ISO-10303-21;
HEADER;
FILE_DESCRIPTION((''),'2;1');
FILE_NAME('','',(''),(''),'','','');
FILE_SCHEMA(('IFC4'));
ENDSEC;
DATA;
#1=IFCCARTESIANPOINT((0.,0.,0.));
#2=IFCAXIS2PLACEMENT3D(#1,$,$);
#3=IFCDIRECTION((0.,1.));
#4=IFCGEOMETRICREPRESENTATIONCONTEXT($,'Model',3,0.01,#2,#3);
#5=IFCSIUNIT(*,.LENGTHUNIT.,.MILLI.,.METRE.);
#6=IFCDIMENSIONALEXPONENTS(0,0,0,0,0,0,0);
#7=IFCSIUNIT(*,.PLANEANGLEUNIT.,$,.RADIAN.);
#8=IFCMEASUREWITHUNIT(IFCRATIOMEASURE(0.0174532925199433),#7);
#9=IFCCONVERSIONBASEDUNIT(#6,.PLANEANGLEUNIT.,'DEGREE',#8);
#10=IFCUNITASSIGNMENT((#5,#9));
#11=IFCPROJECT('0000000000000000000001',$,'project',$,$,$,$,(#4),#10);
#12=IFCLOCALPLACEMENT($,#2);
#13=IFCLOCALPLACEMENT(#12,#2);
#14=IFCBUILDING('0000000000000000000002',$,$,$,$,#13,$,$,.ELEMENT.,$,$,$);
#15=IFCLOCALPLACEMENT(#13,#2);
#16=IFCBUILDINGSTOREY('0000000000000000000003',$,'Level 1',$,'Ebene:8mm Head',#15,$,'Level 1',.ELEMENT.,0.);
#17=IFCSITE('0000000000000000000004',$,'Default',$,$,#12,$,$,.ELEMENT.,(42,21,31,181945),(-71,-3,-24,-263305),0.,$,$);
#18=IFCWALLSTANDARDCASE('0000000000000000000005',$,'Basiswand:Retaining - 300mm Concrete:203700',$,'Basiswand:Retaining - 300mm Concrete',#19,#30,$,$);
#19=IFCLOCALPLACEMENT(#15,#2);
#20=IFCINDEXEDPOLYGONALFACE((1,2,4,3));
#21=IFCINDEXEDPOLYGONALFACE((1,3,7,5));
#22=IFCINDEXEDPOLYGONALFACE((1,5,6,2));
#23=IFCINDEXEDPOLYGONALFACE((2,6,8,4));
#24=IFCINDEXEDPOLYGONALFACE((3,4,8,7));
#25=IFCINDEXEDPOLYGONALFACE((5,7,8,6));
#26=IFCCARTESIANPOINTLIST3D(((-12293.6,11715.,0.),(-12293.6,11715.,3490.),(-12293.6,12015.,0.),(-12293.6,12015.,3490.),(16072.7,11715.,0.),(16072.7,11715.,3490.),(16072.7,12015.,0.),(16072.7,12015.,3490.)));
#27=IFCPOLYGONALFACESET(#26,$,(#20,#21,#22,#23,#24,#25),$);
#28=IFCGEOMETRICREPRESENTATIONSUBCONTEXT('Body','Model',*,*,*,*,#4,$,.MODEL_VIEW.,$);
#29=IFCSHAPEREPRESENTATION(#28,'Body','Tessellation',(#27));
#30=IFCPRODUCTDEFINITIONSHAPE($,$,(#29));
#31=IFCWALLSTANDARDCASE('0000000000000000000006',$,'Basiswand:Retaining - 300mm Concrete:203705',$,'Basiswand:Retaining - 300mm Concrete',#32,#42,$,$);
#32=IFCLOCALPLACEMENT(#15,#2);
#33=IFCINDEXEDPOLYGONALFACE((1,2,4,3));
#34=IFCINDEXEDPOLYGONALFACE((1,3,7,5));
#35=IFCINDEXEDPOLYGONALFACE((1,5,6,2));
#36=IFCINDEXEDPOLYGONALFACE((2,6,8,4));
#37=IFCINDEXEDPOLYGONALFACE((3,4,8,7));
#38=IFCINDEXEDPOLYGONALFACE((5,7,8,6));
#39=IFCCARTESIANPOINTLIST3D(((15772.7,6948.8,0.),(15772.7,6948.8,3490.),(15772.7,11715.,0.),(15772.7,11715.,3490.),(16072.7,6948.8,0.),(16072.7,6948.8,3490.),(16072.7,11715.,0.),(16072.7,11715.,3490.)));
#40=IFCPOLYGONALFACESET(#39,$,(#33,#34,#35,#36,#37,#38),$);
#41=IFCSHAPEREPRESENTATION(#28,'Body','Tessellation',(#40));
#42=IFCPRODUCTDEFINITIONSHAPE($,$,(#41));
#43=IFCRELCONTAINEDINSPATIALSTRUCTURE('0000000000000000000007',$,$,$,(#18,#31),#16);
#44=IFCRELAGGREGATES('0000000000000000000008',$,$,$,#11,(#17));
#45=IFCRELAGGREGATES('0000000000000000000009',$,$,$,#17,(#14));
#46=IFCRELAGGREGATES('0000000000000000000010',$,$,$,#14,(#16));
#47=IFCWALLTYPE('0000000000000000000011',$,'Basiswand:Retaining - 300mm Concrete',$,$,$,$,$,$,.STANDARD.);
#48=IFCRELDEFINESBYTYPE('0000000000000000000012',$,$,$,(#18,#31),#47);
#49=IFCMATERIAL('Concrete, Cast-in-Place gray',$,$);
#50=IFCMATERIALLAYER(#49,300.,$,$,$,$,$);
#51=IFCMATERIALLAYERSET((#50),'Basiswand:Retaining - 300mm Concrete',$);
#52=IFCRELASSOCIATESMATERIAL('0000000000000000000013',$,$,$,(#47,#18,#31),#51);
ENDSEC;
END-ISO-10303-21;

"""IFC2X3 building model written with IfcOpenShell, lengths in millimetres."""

from ifc_helpers import new_model, entity, si_unit, converted_unit, direction, frame, frame_2d, origin, place, context, subcontext, project, spatial, polyline, rectangle, extrude, clip, bounded_halfspace, material, layer, layer_set, layer_usage, type_object, element, save


model = new_model("IFC2X3")

# Units and contexts
model_context = context("Model", 3, precision=0.01, world=origin(), true_north=direction((0.0, 1.0)))
body_context = subcontext(model_context, "Body", "Model", "MODEL_VIEW")
ifc_project = project(units=[si_unit("LENGTHUNIT", "METRE", prefix="MILLI"), converted_unit("PLANEANGLEUNIT", "DEGREE", entity("IfcRatioMeasure", 0.0174532925199433), si_unit("PLANEANGLEUNIT", "RADIAN"), dimensions=[0, 0, 0, 0, 0, 0, 0])], contexts=[model_context])

# Site, building, storey
site_placement = place(None, origin())
site = spatial("IfcSite", under=ifc_project, at=site_placement, Name="Default", CompositionType="ELEMENT", RefLatitude=(42, 21, 31, 181945), RefLongitude=(-71, -3, -24, -263305), RefElevation=0.0)
building_placement = place(site_placement, origin())
building = spatial("IfcBuilding", under=site, at=building_placement, CompositionType="ELEMENT")
storey_placement = place(building_placement, origin())
storey = spatial("IfcBuildingStorey", under=building, at=storey_placement, Name="Level 1", ObjectType="Ebene:8mm Head", LongName="Level 1", CompositionType="ELEMENT", Elevation=0.0)

# Walls
ifc_material_1 = material(Name="Concrete, Cast-in-Place gray")
ifc_layer_1 = layer(ifc_material_1, 300.0)
ifc_layer_set_1 = layer_set([ifc_layer_1], Name="Basiswand:Retaining - 300mm Concrete")
wall_type = type_object("IfcWallType", Name="Basiswand:Retaining - 300mm Concrete", PredefinedType="STANDARD", material=ifc_layer_set_1)
ifc_layer_usage_1 = layer_usage(ifc_layer_set_1, "AXIS2", "NEGATIVE", 150.0)
wall_1_placement = place(storey_placement, frame((-12293.6, 11865.0, 0.0)))
element("IfcWallStandardCase", 1, at=wall_1_placement, inside=storey, type_object=wall_type, material=ifc_layer_usage_1, Name="Basiswand:Retaining - 300mm Concrete:203700", ObjectType="Basiswand:Retaining - 300mm Concrete", context=body_context, shape_type="Clipping", body=[
    clip(extrude(rectangle(XDim=28366.3, YDim=300.0, at=frame_2d((14183.1, 0.0), x_axis=(-1.0, 0.0))), origin(), (0.0, 0.0, 1.0), 3490.0), bounded_halfspace(frame((0.0, -150.0, 3490.0), z_axis=(0.0, 0.0, -1.0), x_axis=(0.0, -1.0, 0.0)), True, frame((0.0, -150.0, 3490.0)), polyline([(0.0, 0.0), (28066.3, 0.0), (28366.3, 0.0), (28366.3, 300.0), (0.0, 300.0), (0.0, 0.0)]))),
])
ifc_layer_usage_2 = layer_usage(ifc_layer_set_1, "AXIS2", "NEGATIVE", 150.0)
wall_2_placement = place(storey_placement, frame((15922.7, 11715.0, 0.0), z_axis=(0.0, 0.0, 1.0), x_axis=(0.0, -1.0, 0.0)))
element("IfcWallStandardCase", 2, at=wall_2_placement, inside=storey, type_object=wall_type, material=ifc_layer_usage_2, Name="Basiswand:Retaining - 300mm Concrete:203705", ObjectType="Basiswand:Retaining - 300mm Concrete", context=body_context, shape_type="Clipping", body=[
    clip(extrude(rectangle(XDim=4766.3, YDim=300.0, at=frame_2d((2383.1, 0.0), x_axis=(-1.0, 0.0))), origin(), (0.0, 0.0, 1.0), 3490.0), bounded_halfspace(frame((0.0, -150.0, 3490.0), z_axis=(0.0, 0.0, -1.0), x_axis=(1.0, 0.0, 0.0)), True, frame((0.0, -150.0, 3490.0)), polyline([(0.0, 0.0), (4766.3, 0.0), (4766.3, 300.0), (0.0, 300.0), (0.0, 0.0)]))),
])

save(model, "model.ifc")
